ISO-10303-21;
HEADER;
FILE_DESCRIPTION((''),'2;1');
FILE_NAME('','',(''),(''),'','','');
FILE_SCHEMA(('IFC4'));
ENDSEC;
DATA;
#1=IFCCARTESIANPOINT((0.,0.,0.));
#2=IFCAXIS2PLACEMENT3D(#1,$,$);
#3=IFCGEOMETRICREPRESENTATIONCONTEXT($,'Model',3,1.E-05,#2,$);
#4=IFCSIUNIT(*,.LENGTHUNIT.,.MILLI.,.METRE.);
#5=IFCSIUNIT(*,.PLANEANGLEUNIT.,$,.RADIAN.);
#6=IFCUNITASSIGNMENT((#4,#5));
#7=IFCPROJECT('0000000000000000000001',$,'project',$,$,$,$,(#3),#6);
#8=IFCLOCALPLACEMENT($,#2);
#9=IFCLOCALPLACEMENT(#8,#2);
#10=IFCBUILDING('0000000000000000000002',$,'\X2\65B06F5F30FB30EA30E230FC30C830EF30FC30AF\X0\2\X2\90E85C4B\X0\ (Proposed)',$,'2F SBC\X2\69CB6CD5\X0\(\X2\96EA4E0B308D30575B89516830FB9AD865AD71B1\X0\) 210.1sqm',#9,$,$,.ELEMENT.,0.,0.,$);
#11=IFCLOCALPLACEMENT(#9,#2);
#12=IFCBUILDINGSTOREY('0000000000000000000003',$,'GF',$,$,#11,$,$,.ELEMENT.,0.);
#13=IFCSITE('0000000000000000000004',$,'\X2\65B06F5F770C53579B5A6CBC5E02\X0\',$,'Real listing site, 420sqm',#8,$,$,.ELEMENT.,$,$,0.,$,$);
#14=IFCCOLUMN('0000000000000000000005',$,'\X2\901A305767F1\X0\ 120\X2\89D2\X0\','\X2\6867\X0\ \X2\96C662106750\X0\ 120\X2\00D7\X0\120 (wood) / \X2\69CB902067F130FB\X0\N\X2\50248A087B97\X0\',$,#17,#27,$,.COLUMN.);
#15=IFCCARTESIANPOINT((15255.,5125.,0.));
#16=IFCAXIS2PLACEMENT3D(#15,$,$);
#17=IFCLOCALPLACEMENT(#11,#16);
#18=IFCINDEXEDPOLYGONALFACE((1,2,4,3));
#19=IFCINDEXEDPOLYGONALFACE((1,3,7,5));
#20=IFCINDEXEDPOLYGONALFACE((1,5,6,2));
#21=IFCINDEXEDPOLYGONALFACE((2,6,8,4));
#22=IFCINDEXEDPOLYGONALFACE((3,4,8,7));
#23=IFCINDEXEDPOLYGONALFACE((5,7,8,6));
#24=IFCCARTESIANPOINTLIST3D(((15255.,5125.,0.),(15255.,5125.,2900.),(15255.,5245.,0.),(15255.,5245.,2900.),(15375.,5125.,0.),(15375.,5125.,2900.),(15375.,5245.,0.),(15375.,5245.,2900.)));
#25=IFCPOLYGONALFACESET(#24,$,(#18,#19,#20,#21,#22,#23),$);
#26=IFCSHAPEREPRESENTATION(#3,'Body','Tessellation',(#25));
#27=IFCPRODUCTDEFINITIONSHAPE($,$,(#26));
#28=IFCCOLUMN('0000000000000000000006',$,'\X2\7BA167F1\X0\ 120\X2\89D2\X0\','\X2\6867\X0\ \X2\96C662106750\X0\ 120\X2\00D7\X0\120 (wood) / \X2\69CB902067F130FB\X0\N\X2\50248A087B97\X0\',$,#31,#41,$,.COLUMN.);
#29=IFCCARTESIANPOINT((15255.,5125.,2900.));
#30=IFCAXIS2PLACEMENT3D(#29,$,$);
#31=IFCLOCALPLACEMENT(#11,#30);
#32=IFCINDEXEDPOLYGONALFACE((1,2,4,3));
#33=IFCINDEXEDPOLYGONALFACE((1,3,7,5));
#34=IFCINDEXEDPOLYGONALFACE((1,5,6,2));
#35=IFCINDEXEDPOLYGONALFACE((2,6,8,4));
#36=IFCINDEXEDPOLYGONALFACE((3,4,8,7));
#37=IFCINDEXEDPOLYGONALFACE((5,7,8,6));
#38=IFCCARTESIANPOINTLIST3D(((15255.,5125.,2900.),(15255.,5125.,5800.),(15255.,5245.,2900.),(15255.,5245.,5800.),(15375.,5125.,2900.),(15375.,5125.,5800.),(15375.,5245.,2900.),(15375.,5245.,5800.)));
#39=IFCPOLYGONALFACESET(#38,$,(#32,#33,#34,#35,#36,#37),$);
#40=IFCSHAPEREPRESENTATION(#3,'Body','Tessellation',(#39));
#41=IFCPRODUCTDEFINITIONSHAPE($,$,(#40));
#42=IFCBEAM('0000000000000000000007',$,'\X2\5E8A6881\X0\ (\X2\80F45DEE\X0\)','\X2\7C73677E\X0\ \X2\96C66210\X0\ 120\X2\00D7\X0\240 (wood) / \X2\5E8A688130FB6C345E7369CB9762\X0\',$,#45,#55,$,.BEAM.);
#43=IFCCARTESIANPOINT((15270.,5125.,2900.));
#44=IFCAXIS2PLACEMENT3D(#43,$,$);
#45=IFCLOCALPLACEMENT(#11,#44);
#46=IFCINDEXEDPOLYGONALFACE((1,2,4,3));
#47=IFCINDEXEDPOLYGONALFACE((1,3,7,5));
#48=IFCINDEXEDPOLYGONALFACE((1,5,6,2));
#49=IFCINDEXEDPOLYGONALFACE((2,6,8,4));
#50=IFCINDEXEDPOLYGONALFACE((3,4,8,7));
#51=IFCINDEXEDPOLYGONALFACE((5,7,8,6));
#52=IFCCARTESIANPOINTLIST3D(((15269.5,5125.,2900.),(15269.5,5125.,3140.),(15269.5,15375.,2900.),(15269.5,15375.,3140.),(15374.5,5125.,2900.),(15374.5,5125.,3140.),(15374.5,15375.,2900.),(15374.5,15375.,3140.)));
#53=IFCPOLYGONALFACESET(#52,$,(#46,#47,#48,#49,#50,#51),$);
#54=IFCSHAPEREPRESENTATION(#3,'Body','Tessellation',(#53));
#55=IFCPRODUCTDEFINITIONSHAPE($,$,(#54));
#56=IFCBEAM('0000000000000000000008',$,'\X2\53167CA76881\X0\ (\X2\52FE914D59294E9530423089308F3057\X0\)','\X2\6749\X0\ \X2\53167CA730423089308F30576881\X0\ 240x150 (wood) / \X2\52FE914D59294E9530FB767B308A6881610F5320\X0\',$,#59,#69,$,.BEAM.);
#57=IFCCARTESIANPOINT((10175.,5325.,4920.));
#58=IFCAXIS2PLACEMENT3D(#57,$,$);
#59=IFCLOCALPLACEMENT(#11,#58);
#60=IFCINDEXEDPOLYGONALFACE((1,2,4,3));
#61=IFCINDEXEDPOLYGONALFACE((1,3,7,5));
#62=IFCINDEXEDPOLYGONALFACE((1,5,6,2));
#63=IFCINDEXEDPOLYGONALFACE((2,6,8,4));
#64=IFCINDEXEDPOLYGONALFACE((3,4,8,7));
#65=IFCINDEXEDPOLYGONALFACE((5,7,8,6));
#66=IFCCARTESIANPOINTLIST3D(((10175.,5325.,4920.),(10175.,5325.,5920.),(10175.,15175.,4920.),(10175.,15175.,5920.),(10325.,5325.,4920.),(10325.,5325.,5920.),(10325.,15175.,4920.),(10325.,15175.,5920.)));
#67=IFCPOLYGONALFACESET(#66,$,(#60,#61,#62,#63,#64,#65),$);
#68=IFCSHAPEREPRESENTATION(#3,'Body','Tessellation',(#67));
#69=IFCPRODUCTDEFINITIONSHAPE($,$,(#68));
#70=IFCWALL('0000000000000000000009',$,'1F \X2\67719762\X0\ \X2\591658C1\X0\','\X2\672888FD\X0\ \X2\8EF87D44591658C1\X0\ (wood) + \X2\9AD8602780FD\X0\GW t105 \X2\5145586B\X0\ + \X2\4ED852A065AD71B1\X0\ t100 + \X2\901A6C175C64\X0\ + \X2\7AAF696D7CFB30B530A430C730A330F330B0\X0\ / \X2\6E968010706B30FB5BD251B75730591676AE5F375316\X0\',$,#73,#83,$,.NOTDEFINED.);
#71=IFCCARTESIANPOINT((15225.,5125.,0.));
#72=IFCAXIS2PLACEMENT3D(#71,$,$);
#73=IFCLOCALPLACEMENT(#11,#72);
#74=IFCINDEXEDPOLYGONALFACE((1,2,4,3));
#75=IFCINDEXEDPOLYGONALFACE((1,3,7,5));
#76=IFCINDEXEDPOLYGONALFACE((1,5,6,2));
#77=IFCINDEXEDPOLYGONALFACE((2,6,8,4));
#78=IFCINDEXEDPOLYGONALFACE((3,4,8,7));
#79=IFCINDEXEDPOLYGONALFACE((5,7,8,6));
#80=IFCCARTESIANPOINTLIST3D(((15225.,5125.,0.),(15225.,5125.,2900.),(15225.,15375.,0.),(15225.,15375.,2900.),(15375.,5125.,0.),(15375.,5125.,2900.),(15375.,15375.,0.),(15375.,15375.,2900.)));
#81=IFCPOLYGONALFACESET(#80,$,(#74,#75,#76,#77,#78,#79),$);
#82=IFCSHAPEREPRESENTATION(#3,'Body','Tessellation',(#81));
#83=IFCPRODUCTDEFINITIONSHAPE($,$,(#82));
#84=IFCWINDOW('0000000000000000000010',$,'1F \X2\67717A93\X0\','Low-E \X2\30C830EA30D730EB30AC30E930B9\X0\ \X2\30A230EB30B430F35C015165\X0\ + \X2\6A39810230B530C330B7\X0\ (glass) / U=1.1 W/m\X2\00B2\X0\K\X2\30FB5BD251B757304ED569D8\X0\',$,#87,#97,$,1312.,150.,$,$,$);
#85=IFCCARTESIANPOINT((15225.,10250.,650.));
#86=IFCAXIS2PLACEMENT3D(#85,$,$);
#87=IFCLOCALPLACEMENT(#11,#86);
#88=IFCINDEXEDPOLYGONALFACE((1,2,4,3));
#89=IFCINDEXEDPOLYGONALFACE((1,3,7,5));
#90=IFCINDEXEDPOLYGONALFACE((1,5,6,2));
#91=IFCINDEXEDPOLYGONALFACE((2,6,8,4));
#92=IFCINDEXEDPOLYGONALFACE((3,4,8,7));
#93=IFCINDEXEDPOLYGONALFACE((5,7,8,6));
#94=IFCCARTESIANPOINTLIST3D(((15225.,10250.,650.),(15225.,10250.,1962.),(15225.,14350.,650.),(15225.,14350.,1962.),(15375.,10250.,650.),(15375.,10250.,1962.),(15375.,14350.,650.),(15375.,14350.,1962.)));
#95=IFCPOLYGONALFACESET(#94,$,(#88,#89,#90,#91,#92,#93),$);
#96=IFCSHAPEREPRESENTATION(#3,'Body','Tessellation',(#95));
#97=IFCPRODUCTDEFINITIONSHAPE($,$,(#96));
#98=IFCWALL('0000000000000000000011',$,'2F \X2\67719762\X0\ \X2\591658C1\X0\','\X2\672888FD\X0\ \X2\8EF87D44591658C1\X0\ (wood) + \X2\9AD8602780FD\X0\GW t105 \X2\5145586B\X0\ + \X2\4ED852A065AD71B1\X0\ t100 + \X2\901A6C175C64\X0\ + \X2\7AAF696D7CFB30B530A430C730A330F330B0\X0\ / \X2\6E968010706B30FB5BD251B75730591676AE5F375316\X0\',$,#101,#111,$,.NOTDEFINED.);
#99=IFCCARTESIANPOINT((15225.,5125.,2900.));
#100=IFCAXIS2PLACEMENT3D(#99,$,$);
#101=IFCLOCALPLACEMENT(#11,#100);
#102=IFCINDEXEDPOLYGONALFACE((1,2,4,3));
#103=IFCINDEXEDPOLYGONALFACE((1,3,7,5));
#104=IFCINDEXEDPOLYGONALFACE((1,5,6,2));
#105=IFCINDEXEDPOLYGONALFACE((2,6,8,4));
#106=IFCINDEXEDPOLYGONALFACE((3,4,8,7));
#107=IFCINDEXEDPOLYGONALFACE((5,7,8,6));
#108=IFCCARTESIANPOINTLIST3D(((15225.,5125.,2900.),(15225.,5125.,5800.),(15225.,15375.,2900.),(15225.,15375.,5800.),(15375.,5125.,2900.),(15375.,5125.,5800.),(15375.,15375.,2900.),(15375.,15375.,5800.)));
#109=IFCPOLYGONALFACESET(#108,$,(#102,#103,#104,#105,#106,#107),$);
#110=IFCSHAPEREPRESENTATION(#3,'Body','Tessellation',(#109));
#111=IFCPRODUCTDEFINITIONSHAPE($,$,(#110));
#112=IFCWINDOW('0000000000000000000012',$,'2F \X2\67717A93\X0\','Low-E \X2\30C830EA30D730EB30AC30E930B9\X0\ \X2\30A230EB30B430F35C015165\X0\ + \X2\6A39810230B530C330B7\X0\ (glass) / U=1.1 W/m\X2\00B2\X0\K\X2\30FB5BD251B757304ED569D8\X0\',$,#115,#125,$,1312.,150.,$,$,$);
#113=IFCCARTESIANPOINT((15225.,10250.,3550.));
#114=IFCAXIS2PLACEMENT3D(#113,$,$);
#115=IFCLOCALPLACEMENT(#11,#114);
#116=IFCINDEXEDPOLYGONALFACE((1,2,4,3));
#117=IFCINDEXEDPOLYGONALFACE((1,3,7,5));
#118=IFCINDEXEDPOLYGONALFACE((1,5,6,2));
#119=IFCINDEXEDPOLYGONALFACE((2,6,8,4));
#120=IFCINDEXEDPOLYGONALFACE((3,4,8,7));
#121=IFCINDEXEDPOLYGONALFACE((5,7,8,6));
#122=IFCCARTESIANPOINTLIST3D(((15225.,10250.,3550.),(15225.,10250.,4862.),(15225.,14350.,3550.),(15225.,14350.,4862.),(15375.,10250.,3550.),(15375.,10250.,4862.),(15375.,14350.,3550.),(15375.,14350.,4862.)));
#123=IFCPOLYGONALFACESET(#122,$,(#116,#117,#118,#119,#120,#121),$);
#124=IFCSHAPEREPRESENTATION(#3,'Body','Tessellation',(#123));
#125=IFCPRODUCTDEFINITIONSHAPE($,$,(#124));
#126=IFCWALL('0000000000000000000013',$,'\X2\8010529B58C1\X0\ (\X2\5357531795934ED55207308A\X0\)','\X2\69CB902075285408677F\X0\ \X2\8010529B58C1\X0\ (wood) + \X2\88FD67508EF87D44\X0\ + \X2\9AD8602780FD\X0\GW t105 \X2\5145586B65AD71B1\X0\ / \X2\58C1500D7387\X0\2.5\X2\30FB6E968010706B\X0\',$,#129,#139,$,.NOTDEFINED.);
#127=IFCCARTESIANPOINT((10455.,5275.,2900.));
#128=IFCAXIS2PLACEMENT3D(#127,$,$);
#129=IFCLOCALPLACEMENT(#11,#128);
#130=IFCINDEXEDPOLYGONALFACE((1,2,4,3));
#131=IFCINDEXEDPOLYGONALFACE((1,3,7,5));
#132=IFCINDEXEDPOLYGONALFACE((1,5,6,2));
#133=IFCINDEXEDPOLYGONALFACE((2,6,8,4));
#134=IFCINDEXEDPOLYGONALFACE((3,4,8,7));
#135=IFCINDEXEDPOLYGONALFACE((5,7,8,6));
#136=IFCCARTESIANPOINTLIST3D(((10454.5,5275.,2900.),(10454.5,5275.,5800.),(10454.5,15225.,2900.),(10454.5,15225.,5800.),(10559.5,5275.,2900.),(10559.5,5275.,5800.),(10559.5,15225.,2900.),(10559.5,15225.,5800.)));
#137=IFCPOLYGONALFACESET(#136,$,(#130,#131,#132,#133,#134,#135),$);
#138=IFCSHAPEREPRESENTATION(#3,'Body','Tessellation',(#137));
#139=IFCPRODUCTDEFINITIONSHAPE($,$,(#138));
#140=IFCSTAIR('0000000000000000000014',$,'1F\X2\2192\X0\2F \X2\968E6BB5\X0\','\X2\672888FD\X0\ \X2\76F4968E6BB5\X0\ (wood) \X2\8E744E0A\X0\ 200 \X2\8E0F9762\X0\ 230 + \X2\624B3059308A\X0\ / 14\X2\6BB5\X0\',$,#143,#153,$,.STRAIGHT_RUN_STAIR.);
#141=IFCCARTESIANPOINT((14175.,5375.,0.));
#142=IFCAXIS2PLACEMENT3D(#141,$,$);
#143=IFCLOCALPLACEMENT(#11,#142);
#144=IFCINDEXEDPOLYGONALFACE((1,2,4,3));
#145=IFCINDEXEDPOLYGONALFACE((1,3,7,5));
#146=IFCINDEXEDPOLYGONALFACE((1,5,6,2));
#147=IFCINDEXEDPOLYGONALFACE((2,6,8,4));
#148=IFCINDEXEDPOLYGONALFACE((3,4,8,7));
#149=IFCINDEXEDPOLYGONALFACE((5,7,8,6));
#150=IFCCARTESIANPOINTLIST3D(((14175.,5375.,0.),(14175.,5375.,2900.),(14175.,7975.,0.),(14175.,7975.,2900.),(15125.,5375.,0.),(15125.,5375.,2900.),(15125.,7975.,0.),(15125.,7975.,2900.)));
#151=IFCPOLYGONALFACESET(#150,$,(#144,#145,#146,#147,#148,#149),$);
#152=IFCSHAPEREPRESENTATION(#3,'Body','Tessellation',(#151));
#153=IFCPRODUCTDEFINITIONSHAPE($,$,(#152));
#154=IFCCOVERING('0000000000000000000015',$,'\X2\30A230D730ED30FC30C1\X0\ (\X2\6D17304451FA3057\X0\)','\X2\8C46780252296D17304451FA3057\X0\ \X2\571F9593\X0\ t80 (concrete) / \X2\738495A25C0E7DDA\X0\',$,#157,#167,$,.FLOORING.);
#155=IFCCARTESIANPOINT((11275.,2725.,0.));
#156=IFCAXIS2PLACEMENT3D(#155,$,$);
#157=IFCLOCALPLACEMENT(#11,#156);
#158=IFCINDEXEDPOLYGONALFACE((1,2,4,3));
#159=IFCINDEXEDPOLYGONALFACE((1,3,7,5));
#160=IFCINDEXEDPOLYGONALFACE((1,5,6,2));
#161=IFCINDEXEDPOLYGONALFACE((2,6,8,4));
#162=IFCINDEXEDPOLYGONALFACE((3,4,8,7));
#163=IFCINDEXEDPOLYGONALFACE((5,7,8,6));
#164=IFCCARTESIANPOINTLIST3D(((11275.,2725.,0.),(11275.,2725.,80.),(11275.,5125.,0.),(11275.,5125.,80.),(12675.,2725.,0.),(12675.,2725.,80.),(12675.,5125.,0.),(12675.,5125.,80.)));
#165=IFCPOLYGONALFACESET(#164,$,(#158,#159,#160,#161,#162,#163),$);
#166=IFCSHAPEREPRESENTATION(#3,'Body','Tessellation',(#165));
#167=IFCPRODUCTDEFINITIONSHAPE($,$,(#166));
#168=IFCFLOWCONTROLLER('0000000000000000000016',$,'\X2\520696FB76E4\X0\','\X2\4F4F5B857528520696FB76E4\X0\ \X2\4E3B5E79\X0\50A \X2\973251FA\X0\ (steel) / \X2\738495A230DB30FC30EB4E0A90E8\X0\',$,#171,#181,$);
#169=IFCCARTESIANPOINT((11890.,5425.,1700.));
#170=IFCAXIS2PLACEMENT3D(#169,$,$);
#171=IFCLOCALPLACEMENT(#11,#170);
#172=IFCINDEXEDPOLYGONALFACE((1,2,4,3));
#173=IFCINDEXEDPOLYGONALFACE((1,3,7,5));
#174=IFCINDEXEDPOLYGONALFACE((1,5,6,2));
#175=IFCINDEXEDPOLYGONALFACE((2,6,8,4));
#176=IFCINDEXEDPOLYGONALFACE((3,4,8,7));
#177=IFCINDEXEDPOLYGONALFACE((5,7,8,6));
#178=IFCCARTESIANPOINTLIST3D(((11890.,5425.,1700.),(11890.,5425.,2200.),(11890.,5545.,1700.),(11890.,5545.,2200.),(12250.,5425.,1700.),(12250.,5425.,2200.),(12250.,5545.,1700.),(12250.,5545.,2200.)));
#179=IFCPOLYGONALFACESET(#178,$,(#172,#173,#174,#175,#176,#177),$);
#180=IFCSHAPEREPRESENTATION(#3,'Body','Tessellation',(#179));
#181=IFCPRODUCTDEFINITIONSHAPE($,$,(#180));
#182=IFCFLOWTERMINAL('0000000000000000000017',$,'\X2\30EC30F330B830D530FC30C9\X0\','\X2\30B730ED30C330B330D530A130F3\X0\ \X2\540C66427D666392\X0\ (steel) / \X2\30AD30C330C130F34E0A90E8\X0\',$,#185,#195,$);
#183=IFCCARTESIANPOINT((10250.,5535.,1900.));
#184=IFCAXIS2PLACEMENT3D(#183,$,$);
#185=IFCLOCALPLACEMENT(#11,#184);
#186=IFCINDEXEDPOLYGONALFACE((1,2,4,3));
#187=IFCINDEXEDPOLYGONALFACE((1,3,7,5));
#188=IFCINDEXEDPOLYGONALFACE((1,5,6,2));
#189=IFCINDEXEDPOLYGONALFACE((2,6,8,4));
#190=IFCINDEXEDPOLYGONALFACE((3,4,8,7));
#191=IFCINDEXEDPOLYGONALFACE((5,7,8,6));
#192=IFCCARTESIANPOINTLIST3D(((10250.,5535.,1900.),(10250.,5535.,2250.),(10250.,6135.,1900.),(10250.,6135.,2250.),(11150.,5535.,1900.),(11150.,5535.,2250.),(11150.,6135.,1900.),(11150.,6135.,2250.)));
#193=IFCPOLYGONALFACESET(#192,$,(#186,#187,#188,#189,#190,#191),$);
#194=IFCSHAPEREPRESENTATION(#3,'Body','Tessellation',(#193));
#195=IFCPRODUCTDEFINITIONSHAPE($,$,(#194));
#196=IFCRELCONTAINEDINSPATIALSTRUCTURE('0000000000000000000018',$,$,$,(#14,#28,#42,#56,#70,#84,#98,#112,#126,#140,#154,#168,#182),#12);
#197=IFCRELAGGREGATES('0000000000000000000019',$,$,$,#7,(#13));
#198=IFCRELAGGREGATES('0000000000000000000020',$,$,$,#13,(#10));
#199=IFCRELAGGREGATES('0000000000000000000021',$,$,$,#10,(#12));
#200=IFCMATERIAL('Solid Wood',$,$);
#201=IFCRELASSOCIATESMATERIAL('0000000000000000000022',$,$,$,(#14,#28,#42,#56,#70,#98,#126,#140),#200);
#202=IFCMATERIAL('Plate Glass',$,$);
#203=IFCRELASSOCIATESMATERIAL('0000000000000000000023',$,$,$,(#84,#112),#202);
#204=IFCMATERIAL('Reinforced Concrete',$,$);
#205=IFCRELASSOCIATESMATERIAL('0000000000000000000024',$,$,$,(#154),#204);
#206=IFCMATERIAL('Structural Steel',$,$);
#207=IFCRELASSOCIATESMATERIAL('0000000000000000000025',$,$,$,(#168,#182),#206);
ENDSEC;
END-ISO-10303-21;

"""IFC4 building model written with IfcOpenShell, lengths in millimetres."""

from ifc_helpers import new_model, si_unit, frame, frame_2d, origin, place, context, project, spatial, rectangle, extrude, material, element, fill, save


model = new_model("IFC4")

# Units and contexts
model_context = context("Model", 3, precision=1e-05, world=origin())
ifc_project = project(units=[si_unit("LENGTHUNIT", "METRE", prefix="MILLI"), si_unit("PLANEANGLEUNIT", "RADIAN")], contexts=[model_context])

# Site, building, storey
site_placement = place(None, origin())
site = spatial("IfcSite", under=ifc_project, at=site_placement, Name="新潟県南魚沼市", ObjectType="Real listing site, 420sqm", CompositionType="ELEMENT", RefElevation=0.0)
building_placement = place(site_placement, origin())
building = spatial("IfcBuilding", under=site, at=building_placement, Name="新潟・リモートワーク2部屋 (Proposed)", ObjectType="2F SBC構法(雪下ろし安全・高断熱) 210.1sqm", CompositionType="ELEMENT", ElevationOfRefHeight=0.0, ElevationOfTerrain=0.0)
storey_placement = place(building_placement, origin())
storey = spatial("IfcBuildingStorey", under=building, at=storey_placement, Name="GF", CompositionType="ELEMENT", Elevation=0.0)

# Columns
ifc_material_1 = material(Name="Solid Wood")
column_1_placement = place(storey_placement, frame((15255.0, 5125.0, 0.0)))
element("IfcColumn", 1, at=column_1_placement, inside=storey, material=ifc_material_1, Name="通し柱 120角", Description="桧 集成材 120×120 (wood) / 構造柱・N値計算", PredefinedType="COLUMN", context=model_context, shape_type="SweptSolid", body=[
    extrude(rectangle(XDim=120.0, YDim=120.0, at=frame_2d((60.0, 60.0))), frame((15255.0, 5125.0, 0.0)), (0.0, 0.0, 1.0), 2900.0),
])
column_2_placement = place(storey_placement, frame((15255.0, 5125.0, 2900.0)))
element("IfcColumn", 2, at=column_2_placement, inside=storey, material=ifc_material_1, Name="管柱 120角", Description="桧 集成材 120×120 (wood) / 構造柱・N値計算", PredefinedType="COLUMN", context=model_context, shape_type="SweptSolid", body=[
    extrude(rectangle(XDim=120.0, YDim=120.0, at=frame_2d((60.0, 60.0))), frame((15255.0, 5125.0, 2900.0)), (0.0, 0.0, 1.0), 2900.0),
])

# Beams
beam_1_placement = place(storey_placement, frame((15270.0, 5125.0, 2900.0)))
element("IfcBeam", 3, at=beam_1_placement, inside=storey, material=ifc_material_1, Name="床梁 (胴差)", Description="米松 集成 120×240 (wood) / 床梁・水平構面", PredefinedType="BEAM", context=model_context, shape_type="SweptSolid", body=[
    extrude(rectangle(XDim=105.0, YDim=10250.0, at=frame_2d((52.0, 5125.0))), frame((15270.0, 5125.0, 2900.0)), (0.0, 0.0, 1.0), 240.0),
])
beam_2_placement = place(storey_placement, frame((10175.0, 5325.0, 4920.0)))
element("IfcBeam", 4, at=beam_2_placement, inside=storey, material=ifc_material_1, Name="化粧梁 (勾配天井あらわし)", Description="杉 化粧あらわし梁 240x150 (wood) / 勾配天井・登り梁意匠", PredefinedType="BEAM", context=model_context, shape_type="SweptSolid", body=[
    extrude(rectangle(XDim=150.0, YDim=9850.0, at=frame_2d((75.0, 4925.0))), frame((10175.0, 5325.0, 4920.0)), (0.0, 0.0, 1.0), 1000.0),
])

# Wall, opening, window
wall_1_placement = place(storey_placement, frame((15225.0, 5125.0, 0.0)))
wall_1 = element("IfcWall", 5, at=wall_1_placement, inside=storey, material=ifc_material_1, Name="1F 東面 外壁", Description="木製 軸組外壁 (wood) + 高性能GW t105 充填 + 付加断熱 t100 + 通気層 + 窯業系サイディング / 準耐火・寒冷地外皮強化", PredefinedType="NOTDEFINED", context=model_context, shape_type="SweptSolid", body=[
    extrude(rectangle(XDim=150.0, YDim=10250.0, at=frame_2d((75.0, 5125.0))), frame((15225.0, 5125.0, 0.0)), (0.0, 0.0, 1.0), 2900.0),
])
opening_1_placement = place(storey_placement, frame((15225.0, 10250.0, 650.0)))
opening_1 = element("IfcOpeningElement", 6, at=opening_1_placement, cuts=wall_1, PredefinedType="NOTDEFINED", context=model_context, shape_type="SweptSolid", body=[
    extrude(rectangle(XDim=150.0, YDim=4100.0, at=frame_2d((75.0, 2050.0))), frame((15225.0, 10250.0, 650.0)), (0.0, 0.0, 1.0), 1312.0),
])
ifc_material_2 = material(Name="Plate Glass")
window_1_placement = place(storey_placement, frame((15225.0, 10250.0, 650.0)))
window_1 = element("IfcWindow", 7, at=window_1_placement, inside=storey, material=ifc_material_2, Name="1F 東窓", Description="Low-E トリプルガラス アルゴン封入 + 樹脂サッシ (glass) / U=1.1 W/m²K・寒冷地仕様", OverallHeight=1312.0, OverallWidth=150.0, context=model_context, shape_type="SweptSolid", body=[
    extrude(rectangle(XDim=150.0, YDim=4100.0, at=frame_2d((75.0, 2050.0))), frame((15225.0, 10250.0, 650.0)), (0.0, 0.0, 1.0), 1312.0),
])
fill(opening_1, window_1)

# Wall, opening, window
wall_2_placement = place(storey_placement, frame((15225.0, 5125.0, 2900.0)))
wall_2 = element("IfcWall", 8, at=wall_2_placement, inside=storey, material=ifc_material_1, Name="2F 東面 外壁", Description="木製 軸組外壁 (wood) + 高性能GW t105 充填 + 付加断熱 t100 + 通気層 + 窯業系サイディング / 準耐火・寒冷地外皮強化", PredefinedType="NOTDEFINED", context=model_context, shape_type="SweptSolid", body=[
    extrude(rectangle(XDim=150.0, YDim=10250.0, at=frame_2d((75.0, 5125.0))), frame((15225.0, 5125.0, 2900.0)), (0.0, 0.0, 1.0), 2900.0),
])
opening_2_placement = place(storey_placement, frame((15225.0, 10250.0, 3550.0)))
opening_2 = element("IfcOpeningElement", 9, at=opening_2_placement, cuts=wall_2, PredefinedType="NOTDEFINED", context=model_context, shape_type="SweptSolid", body=[
    extrude(rectangle(XDim=150.0, YDim=4100.0, at=frame_2d((75.0, 2050.0))), frame((15225.0, 10250.0, 3550.0)), (0.0, 0.0, 1.0), 1312.0),
])
window_2_placement = place(storey_placement, frame((15225.0, 10250.0, 3550.0)))
window_2 = element("IfcWindow", 10, at=window_2_placement, inside=storey, material=ifc_material_2, Name="2F 東窓", Description="Low-E トリプルガラス アルゴン封入 + 樹脂サッシ (glass) / U=1.1 W/m²K・寒冷地仕様", OverallHeight=1312.0, OverallWidth=150.0, context=model_context, shape_type="SweptSolid", body=[
    extrude(rectangle(XDim=150.0, YDim=4100.0, at=frame_2d((75.0, 2050.0))), frame((15225.0, 10250.0, 3550.0)), (0.0, 0.0, 1.0), 1312.0),
])
fill(opening_2, window_2)

# Wall
wall_3_placement = place(storey_placement, frame((10455.0, 5275.0, 2900.0)))
element("IfcWall", 11, at=wall_3_placement, inside=storey, material=ifc_material_1, Name="耐力壁 (南北間仕切り)", Description="構造用合板 耐力壁 (wood) + 製材軸組 + 高性能GW t105 充填断熱 / 壁倍率2.5・準耐火", PredefinedType="NOTDEFINED", context=model_context, shape_type="SweptSolid", body=[
    extrude(rectangle(XDim=105.0, YDim=9950.0, at=frame_2d((52.0, 4975.0))), frame((10455.0, 5275.0, 2900.0)), (0.0, 0.0, 1.0), 2900.0),
])

# Stair
stair_placement = place(storey_placement, frame((14175.0, 5375.0, 0.0)))
element("IfcStair", 12, at=stair_placement, inside=storey, material=ifc_material_1, Name="1F→2F 階段", Description="木製 直階段 (wood) 蹴上 200 踏面 230 + 手すり / 14段", PredefinedType="STRAIGHT_RUN_STAIR", context=model_context, shape_type="SweptSolid", body=[
    extrude(rectangle(XDim=950.0, YDim=2600.0, at=frame_2d((475.0, 1300.0))), frame((14175.0, 5375.0, 0.0)), (0.0, 0.0, 1.0), 2900.0),
])

# Covering
ifc_material_3 = material(Name="Reinforced Concrete")
covering_placement = place(storey_placement, frame((11275.0, 2725.0, 0.0)))
element("IfcCovering", 13, at=covering_placement, inside=storey, material=ifc_material_3, Name="アプローチ (洗い出し)", Description="豆砂利洗い出し 土間 t80 (concrete) / 玄関導線", PredefinedType="FLOORING", context=model_context, shape_type="SweptSolid", body=[
    extrude(rectangle(XDim=1400.0, YDim=2400.0, at=frame_2d((700.0, 1200.0))), frame((11275.0, 2725.0, 0.0)), (0.0, 0.0, 1.0), 80.0),
])

# Flow controller
ifc_material_4 = material(Name="Structural Steel")
flow_controller_placement = place(storey_placement, frame((11890.0, 5425.0, 1700.0)))
element("IfcFlowController", 14, at=flow_controller_placement, inside=storey, material=ifc_material_4, Name="分電盤", Description="住宅用分電盤 主幹50A 露出 (steel) / 玄関ホール上部", context=model_context, shape_type="SweptSolid", body=[
    extrude(rectangle(XDim=360.0, YDim=120.0, at=frame_2d((180.0, 60.0))), frame((11890.0, 5425.0, 1700.0)), (0.0, 0.0, 1.0), 500.0),
])

# Flow terminal
flow_terminal_1_placement = place(storey_placement, frame((10250.0, 5535.0, 1900.0)))
element("IfcFlowTerminal", 15, at=flow_terminal_1_placement, inside=storey, material=ifc_material_4, Name="レンジフード", Description="シロッコファン 同時給排 (steel) / キッチン上部", context=model_context, shape_type="SweptSolid", body=[
    extrude(rectangle(XDim=900.0, YDim=600.0, at=frame_2d((450.0, 300.0))), frame((10250.0, 5535.0, 1900.0)), (0.0, 0.0, 1.0), 350.0),
])

save(model, "model.ifc")
